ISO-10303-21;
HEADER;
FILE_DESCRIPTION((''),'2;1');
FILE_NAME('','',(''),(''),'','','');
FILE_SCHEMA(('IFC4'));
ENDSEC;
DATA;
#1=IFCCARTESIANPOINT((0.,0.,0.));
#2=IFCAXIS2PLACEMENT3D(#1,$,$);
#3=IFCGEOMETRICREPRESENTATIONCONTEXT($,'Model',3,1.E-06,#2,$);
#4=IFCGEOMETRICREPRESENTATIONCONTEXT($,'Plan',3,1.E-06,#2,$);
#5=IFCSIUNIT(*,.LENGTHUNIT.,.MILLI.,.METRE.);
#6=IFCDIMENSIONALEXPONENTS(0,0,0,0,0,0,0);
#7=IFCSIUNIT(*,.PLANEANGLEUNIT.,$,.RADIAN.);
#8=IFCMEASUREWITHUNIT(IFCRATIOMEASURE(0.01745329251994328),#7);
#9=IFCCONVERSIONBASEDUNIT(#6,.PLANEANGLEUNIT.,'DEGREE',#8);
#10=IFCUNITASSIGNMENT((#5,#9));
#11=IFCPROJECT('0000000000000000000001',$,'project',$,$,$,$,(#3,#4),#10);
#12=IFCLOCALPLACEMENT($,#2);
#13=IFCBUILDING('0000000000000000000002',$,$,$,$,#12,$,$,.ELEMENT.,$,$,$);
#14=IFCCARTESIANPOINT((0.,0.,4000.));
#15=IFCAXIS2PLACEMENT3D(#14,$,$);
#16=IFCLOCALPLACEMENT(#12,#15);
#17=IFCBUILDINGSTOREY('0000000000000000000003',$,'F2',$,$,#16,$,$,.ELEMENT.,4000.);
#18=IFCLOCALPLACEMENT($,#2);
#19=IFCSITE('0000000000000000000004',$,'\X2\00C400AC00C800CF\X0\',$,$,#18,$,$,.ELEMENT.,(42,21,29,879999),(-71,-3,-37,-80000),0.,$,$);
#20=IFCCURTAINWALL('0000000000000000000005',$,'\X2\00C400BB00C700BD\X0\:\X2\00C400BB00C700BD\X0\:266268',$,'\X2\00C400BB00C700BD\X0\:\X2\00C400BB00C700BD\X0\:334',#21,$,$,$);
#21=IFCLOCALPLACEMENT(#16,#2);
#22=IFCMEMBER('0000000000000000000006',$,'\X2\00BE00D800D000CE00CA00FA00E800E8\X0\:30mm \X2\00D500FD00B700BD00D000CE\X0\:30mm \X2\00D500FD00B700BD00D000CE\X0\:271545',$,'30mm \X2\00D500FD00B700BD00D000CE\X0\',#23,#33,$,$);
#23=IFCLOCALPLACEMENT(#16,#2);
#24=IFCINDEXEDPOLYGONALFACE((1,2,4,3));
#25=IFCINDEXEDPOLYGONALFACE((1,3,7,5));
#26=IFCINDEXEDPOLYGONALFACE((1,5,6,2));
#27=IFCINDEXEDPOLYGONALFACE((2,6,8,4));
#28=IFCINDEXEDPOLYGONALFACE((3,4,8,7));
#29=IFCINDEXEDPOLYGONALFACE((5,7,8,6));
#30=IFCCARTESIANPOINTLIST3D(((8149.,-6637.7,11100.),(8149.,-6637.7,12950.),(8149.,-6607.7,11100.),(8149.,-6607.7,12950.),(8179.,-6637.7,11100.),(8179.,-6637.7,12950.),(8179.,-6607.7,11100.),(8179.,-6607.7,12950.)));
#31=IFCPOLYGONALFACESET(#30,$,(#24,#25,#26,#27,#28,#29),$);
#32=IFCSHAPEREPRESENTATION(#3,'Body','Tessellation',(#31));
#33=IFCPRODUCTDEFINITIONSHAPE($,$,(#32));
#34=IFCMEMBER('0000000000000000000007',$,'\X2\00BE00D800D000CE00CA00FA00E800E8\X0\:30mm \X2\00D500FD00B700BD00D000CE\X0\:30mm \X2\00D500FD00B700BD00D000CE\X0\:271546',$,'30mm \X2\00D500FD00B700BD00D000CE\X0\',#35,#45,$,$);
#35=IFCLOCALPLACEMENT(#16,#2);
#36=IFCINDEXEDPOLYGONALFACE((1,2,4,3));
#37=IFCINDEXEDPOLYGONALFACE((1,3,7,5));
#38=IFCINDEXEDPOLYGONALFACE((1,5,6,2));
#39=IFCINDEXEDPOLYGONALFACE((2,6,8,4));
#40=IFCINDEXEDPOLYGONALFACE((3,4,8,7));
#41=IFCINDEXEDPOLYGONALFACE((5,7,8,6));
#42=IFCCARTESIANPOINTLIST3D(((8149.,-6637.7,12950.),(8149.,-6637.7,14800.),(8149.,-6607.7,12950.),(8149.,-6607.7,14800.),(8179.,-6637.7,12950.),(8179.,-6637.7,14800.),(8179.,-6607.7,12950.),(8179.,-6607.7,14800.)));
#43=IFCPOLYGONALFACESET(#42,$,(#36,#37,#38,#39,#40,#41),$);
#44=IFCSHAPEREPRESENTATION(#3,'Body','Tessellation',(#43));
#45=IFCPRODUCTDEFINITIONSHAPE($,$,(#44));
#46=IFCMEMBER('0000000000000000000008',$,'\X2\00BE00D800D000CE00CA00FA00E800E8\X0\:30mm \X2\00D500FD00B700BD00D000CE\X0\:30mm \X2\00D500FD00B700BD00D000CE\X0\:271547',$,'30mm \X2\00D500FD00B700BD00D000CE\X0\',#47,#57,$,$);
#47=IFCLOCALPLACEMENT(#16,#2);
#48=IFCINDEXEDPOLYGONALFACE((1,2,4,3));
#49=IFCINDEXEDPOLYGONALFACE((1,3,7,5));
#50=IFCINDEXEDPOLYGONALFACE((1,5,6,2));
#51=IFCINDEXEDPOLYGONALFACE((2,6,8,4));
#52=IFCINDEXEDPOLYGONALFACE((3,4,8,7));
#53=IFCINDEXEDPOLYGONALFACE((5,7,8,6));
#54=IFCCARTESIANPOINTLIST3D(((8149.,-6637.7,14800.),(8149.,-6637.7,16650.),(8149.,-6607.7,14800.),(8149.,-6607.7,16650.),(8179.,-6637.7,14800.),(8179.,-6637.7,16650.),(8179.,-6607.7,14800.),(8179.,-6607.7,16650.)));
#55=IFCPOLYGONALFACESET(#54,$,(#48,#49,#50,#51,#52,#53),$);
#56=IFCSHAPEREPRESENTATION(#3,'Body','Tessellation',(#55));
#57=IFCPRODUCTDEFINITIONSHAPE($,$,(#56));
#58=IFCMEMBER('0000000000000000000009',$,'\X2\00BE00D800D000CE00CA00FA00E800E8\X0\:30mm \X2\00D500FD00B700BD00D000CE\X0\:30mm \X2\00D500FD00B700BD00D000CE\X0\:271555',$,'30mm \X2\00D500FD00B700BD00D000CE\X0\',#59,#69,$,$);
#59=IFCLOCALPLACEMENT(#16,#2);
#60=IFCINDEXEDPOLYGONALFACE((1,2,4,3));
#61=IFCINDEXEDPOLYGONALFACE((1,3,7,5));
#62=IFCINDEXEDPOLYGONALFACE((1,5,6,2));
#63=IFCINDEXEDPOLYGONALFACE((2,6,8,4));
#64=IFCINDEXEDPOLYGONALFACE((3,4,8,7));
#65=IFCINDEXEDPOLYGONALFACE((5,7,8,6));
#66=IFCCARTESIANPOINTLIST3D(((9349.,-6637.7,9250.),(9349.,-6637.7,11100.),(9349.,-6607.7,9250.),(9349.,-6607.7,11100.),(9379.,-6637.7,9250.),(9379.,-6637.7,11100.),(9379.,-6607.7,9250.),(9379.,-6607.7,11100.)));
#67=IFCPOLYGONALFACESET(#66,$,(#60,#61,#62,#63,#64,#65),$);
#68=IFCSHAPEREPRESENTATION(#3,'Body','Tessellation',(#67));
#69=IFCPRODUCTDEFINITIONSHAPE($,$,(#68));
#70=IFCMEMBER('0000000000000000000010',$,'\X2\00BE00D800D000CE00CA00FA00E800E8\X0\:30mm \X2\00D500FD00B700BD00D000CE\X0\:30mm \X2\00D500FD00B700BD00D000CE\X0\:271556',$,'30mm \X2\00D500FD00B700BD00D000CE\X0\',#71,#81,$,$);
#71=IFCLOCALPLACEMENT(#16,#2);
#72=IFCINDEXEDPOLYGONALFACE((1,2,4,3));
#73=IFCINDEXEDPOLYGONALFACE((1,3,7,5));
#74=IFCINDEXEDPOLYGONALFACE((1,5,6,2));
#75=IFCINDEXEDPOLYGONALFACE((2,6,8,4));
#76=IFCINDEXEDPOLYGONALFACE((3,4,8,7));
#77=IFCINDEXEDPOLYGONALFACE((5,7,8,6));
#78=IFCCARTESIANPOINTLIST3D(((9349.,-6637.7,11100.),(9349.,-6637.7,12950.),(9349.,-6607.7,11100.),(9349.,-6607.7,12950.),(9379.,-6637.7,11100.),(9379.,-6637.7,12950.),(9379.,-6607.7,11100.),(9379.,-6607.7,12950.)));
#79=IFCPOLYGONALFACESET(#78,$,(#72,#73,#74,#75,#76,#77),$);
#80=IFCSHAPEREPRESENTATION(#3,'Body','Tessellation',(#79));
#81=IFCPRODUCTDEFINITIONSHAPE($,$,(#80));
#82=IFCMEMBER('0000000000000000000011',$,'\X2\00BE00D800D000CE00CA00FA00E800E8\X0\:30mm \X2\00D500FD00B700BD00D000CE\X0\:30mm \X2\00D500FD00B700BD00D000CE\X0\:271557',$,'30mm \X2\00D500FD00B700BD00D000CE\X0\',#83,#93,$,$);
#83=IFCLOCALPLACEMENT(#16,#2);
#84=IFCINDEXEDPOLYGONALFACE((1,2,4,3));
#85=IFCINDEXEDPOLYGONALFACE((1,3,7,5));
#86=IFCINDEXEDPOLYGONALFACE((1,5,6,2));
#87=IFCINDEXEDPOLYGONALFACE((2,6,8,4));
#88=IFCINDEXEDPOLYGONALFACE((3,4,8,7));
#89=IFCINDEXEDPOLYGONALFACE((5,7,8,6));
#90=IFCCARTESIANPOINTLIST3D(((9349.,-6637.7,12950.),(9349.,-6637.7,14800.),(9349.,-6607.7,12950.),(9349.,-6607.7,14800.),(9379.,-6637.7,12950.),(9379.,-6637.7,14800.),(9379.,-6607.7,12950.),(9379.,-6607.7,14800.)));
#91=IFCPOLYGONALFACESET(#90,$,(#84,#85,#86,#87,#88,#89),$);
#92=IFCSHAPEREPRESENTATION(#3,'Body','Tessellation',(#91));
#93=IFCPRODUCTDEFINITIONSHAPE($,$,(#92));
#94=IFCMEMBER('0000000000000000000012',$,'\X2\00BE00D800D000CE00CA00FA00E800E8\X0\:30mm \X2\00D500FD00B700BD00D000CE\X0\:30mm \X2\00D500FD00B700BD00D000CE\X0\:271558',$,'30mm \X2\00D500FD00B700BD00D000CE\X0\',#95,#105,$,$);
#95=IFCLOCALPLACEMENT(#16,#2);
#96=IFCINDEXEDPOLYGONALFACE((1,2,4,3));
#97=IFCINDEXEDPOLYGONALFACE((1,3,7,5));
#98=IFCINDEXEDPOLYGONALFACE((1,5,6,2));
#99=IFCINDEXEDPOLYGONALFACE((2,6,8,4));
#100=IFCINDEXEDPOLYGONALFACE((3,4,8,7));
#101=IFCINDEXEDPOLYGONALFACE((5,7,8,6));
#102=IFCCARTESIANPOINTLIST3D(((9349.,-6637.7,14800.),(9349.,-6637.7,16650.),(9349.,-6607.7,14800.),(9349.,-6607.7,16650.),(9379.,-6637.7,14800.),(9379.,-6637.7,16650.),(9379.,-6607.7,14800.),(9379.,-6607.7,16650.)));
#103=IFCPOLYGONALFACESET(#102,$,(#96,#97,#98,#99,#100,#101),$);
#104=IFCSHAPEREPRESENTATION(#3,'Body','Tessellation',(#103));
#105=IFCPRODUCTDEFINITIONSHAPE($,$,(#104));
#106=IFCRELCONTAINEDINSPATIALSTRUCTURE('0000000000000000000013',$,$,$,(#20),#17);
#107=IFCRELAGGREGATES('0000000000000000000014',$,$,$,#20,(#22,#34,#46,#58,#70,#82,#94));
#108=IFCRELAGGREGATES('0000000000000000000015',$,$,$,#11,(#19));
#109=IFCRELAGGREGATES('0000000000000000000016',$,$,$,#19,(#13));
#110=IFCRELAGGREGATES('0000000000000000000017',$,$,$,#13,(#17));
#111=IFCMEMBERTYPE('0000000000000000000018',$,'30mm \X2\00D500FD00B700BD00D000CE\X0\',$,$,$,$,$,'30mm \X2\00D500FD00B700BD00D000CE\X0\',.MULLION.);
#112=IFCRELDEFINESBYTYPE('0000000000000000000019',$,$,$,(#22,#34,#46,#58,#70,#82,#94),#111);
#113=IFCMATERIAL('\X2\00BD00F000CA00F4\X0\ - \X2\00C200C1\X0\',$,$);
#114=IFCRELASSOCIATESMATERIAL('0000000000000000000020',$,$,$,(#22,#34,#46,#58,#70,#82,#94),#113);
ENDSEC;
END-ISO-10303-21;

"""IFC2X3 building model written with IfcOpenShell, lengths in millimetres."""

from ifc_helpers import new_model, entity, si_unit, converted_unit, frame, origin, origin_2d_with_axis, place, context, project, spatial, rectangle, extrude, source, transform, mapped, material, type_object, type_shapes, element, aggregate, save


model = new_model("IFC2X3")

# Units and contexts
model_context = context("Model", 3, precision=1e-06, world=origin())
plan_context = context("Plan", 3, precision=1e-06, world=origin())
ifc_project = project(units=[si_unit("LENGTHUNIT", "METRE", prefix="MILLI"), converted_unit("PLANEANGLEUNIT", "DEGREE", entity("IfcRatioMeasure", 0.01745329251994328), si_unit("PLANEANGLEUNIT", "RADIAN"), dimensions=[0, 0, 0, 0, 0, 0, 0])], contexts=[model_context, plan_context])

# Site, building, storey
site_placement = place(None, origin())
site = spatial("IfcSite", under=ifc_project, at=site_placement, Name="Ä¬ÈÏ", CompositionType="ELEMENT", RefLatitude=(42, 21, 29, 879999), RefLongitude=(-71, -3, -37, -80000), RefElevation=0.0)
building_placement = place(None, origin())
building = spatial("IfcBuilding", under=site, at=building_placement, CompositionType="ELEMENT")
storey_placement = place(building_placement, frame((0.0, 0.0, 4000.0)))
storey = spatial("IfcBuildingStorey", under=building, at=storey_placement, Name="F2", CompositionType="ELEMENT", Elevation=4000.0)

# Curtain wall, members
curtain_wall_placement = place(storey_placement, origin())
curtain_wall = element("IfcCurtainWall", 1, at=curtain_wall_placement, inside=storey, Name="Ä»Ç½:Ä»Ç½:266268", ObjectType="Ä»Ç½:Ä»Ç½:334")
ifc_material_1 = material(Name="½ðÊô - ÂÁ")
placement_1 = place(building_placement, frame((0.0, 0.0, 15100.0)))
placement_2 = place(building_placement, frame((0.0, 0.0, 11400.0)))
placement_3 = place(building_placement, frame((0.0, 0.0, 18800.0)))
member_type_1 = type_object("IfcMemberType", Name="30mm Õý·½ÐÎ", ElementType="30mm Õý·½ÐÎ", PredefinedType="MULLION")
shared_shape_1 = source(origin(), model_context, "Body", "SweptSolid", [
    extrude(rectangle(XDim=30.0, YDim=30.0, at=origin_2d_with_axis()), frame((0.0, 0.0, -1850.0), z_axis=(0.0, 0.0, 1.0), x_axis=(-1.0, 0.0, 0.0)), (0.0, 0.0, 1.0), 1850.0),
])
type_shapes(member_type_1, [shared_shape_1])
member_1_placement = place(placement_1, frame((8164.0, -6622.7, 0.0), z_axis=(0.0, 0.0, -1.0), x_axis=(1.0, 0.0, 0.0)))
member_1 = element("IfcMember", 2, at=member_1_placement, type_object=member_type_1, material=ifc_material_1, Name="¾ØÐÎÊúèè:30mm Õý·½ÐÎ:30mm Õý·½ÐÎ:271545", ObjectType="30mm Õý·½ÐÎ", context=model_context, shape_type="MappedRepresentation", body=[
    mapped(shared_shape_1, transform((0.0, 0.0, 0.0), scale=1.0)),
])
member_2_placement = place(placement_1, frame((8164.0, -6622.7, 1850.0), z_axis=(0.0, 0.0, -1.0), x_axis=(1.0, 0.0, 0.0)))
member_2 = element("IfcMember", 3, at=member_2_placement, type_object=member_type_1, material=ifc_material_1, Name="¾ØÐÎÊúèè:30mm Õý·½ÐÎ:30mm Õý·½ÐÎ:271546", ObjectType="30mm Õý·½ÐÎ", context=model_context, shape_type="MappedRepresentation", body=[
    mapped(shared_shape_1, transform((0.0, 0.0, 0.0), scale=1.0)),
])
member_3_placement = place(placement_3, frame((8164.0, -6622.7, 0.0), z_axis=(0.0, 0.0, -1.0), x_axis=(1.0, 0.0, 0.0)))
member_3 = element("IfcMember", 4, at=member_3_placement, type_object=member_type_1, material=ifc_material_1, Name="¾ØÐÎÊúèè:30mm Õý·½ÐÎ:30mm Õý·½ÐÎ:271547", ObjectType="30mm Õý·½ÐÎ", context=model_context, shape_type="MappedRepresentation", body=[
    mapped(shared_shape_1, transform((0.0, 0.0, 0.0), scale=1.0)),
])
member_4_placement = place(placement_2, frame((9364.0, -6622.7, 1850.0), z_axis=(0.0, 0.0, -1.0), x_axis=(1.0, 0.0, 0.0)))
member_4 = element("IfcMember", 5, at=member_4_placement, type_object=member_type_1, material=ifc_material_1, Name="¾ØÐÎÊúèè:30mm Õý·½ÐÎ:30mm Õý·½ÐÎ:271555", ObjectType="30mm Õý·½ÐÎ", context=model_context, shape_type="MappedRepresentation", body=[
    mapped(shared_shape_1, transform((0.0, 0.0, 0.0), scale=1.0)),
])
member_5_placement = place(placement_1, frame((9364.0, -6622.7, 0.0), z_axis=(0.0, 0.0, -1.0), x_axis=(1.0, 0.0, 0.0)))
member_5 = element("IfcMember", 6, at=member_5_placement, type_object=member_type_1, material=ifc_material_1, Name="¾ØÐÎÊúèè:30mm Õý·½ÐÎ:30mm Õý·½ÐÎ:271556", ObjectType="30mm Õý·½ÐÎ", context=model_context, shape_type="MappedRepresentation", body=[
    mapped(shared_shape_1, transform((0.0, 0.0, 0.0), scale=1.0)),
])
member_6_placement = place(placement_1, frame((9364.0, -6622.7, 1850.0), z_axis=(0.0, 0.0, -1.0), x_axis=(1.0, 0.0, 0.0)))
member_6 = element("IfcMember", 7, at=member_6_placement, type_object=member_type_1, material=ifc_material_1, Name="¾ØÐÎÊúèè:30mm Õý·½ÐÎ:30mm Õý·½ÐÎ:271557", ObjectType="30mm Õý·½ÐÎ", context=model_context, shape_type="MappedRepresentation", body=[
    mapped(shared_shape_1, transform((0.0, 0.0, 0.0), scale=1.0)),
])
member_7_placement = place(placement_3, frame((9364.0, -6622.7, 0.0), z_axis=(0.0, 0.0, -1.0), x_axis=(1.0, 0.0, 0.0)))
member_7 = element("IfcMember", 8, at=member_7_placement, type_object=member_type_1, material=ifc_material_1, Name="¾ØÐÎÊúèè:30mm Õý·½ÐÎ:30mm Õý·½ÐÎ:271558", ObjectType="30mm Õý·½ÐÎ", context=model_context, shape_type="MappedRepresentation", body=[
    mapped(shared_shape_1, transform((0.0, 0.0, 0.0), scale=1.0)),
])
aggregate(curtain_wall, [member_1, member_2, member_3, member_4, member_5, member_6, member_7])

save(model, "model.ifc")
